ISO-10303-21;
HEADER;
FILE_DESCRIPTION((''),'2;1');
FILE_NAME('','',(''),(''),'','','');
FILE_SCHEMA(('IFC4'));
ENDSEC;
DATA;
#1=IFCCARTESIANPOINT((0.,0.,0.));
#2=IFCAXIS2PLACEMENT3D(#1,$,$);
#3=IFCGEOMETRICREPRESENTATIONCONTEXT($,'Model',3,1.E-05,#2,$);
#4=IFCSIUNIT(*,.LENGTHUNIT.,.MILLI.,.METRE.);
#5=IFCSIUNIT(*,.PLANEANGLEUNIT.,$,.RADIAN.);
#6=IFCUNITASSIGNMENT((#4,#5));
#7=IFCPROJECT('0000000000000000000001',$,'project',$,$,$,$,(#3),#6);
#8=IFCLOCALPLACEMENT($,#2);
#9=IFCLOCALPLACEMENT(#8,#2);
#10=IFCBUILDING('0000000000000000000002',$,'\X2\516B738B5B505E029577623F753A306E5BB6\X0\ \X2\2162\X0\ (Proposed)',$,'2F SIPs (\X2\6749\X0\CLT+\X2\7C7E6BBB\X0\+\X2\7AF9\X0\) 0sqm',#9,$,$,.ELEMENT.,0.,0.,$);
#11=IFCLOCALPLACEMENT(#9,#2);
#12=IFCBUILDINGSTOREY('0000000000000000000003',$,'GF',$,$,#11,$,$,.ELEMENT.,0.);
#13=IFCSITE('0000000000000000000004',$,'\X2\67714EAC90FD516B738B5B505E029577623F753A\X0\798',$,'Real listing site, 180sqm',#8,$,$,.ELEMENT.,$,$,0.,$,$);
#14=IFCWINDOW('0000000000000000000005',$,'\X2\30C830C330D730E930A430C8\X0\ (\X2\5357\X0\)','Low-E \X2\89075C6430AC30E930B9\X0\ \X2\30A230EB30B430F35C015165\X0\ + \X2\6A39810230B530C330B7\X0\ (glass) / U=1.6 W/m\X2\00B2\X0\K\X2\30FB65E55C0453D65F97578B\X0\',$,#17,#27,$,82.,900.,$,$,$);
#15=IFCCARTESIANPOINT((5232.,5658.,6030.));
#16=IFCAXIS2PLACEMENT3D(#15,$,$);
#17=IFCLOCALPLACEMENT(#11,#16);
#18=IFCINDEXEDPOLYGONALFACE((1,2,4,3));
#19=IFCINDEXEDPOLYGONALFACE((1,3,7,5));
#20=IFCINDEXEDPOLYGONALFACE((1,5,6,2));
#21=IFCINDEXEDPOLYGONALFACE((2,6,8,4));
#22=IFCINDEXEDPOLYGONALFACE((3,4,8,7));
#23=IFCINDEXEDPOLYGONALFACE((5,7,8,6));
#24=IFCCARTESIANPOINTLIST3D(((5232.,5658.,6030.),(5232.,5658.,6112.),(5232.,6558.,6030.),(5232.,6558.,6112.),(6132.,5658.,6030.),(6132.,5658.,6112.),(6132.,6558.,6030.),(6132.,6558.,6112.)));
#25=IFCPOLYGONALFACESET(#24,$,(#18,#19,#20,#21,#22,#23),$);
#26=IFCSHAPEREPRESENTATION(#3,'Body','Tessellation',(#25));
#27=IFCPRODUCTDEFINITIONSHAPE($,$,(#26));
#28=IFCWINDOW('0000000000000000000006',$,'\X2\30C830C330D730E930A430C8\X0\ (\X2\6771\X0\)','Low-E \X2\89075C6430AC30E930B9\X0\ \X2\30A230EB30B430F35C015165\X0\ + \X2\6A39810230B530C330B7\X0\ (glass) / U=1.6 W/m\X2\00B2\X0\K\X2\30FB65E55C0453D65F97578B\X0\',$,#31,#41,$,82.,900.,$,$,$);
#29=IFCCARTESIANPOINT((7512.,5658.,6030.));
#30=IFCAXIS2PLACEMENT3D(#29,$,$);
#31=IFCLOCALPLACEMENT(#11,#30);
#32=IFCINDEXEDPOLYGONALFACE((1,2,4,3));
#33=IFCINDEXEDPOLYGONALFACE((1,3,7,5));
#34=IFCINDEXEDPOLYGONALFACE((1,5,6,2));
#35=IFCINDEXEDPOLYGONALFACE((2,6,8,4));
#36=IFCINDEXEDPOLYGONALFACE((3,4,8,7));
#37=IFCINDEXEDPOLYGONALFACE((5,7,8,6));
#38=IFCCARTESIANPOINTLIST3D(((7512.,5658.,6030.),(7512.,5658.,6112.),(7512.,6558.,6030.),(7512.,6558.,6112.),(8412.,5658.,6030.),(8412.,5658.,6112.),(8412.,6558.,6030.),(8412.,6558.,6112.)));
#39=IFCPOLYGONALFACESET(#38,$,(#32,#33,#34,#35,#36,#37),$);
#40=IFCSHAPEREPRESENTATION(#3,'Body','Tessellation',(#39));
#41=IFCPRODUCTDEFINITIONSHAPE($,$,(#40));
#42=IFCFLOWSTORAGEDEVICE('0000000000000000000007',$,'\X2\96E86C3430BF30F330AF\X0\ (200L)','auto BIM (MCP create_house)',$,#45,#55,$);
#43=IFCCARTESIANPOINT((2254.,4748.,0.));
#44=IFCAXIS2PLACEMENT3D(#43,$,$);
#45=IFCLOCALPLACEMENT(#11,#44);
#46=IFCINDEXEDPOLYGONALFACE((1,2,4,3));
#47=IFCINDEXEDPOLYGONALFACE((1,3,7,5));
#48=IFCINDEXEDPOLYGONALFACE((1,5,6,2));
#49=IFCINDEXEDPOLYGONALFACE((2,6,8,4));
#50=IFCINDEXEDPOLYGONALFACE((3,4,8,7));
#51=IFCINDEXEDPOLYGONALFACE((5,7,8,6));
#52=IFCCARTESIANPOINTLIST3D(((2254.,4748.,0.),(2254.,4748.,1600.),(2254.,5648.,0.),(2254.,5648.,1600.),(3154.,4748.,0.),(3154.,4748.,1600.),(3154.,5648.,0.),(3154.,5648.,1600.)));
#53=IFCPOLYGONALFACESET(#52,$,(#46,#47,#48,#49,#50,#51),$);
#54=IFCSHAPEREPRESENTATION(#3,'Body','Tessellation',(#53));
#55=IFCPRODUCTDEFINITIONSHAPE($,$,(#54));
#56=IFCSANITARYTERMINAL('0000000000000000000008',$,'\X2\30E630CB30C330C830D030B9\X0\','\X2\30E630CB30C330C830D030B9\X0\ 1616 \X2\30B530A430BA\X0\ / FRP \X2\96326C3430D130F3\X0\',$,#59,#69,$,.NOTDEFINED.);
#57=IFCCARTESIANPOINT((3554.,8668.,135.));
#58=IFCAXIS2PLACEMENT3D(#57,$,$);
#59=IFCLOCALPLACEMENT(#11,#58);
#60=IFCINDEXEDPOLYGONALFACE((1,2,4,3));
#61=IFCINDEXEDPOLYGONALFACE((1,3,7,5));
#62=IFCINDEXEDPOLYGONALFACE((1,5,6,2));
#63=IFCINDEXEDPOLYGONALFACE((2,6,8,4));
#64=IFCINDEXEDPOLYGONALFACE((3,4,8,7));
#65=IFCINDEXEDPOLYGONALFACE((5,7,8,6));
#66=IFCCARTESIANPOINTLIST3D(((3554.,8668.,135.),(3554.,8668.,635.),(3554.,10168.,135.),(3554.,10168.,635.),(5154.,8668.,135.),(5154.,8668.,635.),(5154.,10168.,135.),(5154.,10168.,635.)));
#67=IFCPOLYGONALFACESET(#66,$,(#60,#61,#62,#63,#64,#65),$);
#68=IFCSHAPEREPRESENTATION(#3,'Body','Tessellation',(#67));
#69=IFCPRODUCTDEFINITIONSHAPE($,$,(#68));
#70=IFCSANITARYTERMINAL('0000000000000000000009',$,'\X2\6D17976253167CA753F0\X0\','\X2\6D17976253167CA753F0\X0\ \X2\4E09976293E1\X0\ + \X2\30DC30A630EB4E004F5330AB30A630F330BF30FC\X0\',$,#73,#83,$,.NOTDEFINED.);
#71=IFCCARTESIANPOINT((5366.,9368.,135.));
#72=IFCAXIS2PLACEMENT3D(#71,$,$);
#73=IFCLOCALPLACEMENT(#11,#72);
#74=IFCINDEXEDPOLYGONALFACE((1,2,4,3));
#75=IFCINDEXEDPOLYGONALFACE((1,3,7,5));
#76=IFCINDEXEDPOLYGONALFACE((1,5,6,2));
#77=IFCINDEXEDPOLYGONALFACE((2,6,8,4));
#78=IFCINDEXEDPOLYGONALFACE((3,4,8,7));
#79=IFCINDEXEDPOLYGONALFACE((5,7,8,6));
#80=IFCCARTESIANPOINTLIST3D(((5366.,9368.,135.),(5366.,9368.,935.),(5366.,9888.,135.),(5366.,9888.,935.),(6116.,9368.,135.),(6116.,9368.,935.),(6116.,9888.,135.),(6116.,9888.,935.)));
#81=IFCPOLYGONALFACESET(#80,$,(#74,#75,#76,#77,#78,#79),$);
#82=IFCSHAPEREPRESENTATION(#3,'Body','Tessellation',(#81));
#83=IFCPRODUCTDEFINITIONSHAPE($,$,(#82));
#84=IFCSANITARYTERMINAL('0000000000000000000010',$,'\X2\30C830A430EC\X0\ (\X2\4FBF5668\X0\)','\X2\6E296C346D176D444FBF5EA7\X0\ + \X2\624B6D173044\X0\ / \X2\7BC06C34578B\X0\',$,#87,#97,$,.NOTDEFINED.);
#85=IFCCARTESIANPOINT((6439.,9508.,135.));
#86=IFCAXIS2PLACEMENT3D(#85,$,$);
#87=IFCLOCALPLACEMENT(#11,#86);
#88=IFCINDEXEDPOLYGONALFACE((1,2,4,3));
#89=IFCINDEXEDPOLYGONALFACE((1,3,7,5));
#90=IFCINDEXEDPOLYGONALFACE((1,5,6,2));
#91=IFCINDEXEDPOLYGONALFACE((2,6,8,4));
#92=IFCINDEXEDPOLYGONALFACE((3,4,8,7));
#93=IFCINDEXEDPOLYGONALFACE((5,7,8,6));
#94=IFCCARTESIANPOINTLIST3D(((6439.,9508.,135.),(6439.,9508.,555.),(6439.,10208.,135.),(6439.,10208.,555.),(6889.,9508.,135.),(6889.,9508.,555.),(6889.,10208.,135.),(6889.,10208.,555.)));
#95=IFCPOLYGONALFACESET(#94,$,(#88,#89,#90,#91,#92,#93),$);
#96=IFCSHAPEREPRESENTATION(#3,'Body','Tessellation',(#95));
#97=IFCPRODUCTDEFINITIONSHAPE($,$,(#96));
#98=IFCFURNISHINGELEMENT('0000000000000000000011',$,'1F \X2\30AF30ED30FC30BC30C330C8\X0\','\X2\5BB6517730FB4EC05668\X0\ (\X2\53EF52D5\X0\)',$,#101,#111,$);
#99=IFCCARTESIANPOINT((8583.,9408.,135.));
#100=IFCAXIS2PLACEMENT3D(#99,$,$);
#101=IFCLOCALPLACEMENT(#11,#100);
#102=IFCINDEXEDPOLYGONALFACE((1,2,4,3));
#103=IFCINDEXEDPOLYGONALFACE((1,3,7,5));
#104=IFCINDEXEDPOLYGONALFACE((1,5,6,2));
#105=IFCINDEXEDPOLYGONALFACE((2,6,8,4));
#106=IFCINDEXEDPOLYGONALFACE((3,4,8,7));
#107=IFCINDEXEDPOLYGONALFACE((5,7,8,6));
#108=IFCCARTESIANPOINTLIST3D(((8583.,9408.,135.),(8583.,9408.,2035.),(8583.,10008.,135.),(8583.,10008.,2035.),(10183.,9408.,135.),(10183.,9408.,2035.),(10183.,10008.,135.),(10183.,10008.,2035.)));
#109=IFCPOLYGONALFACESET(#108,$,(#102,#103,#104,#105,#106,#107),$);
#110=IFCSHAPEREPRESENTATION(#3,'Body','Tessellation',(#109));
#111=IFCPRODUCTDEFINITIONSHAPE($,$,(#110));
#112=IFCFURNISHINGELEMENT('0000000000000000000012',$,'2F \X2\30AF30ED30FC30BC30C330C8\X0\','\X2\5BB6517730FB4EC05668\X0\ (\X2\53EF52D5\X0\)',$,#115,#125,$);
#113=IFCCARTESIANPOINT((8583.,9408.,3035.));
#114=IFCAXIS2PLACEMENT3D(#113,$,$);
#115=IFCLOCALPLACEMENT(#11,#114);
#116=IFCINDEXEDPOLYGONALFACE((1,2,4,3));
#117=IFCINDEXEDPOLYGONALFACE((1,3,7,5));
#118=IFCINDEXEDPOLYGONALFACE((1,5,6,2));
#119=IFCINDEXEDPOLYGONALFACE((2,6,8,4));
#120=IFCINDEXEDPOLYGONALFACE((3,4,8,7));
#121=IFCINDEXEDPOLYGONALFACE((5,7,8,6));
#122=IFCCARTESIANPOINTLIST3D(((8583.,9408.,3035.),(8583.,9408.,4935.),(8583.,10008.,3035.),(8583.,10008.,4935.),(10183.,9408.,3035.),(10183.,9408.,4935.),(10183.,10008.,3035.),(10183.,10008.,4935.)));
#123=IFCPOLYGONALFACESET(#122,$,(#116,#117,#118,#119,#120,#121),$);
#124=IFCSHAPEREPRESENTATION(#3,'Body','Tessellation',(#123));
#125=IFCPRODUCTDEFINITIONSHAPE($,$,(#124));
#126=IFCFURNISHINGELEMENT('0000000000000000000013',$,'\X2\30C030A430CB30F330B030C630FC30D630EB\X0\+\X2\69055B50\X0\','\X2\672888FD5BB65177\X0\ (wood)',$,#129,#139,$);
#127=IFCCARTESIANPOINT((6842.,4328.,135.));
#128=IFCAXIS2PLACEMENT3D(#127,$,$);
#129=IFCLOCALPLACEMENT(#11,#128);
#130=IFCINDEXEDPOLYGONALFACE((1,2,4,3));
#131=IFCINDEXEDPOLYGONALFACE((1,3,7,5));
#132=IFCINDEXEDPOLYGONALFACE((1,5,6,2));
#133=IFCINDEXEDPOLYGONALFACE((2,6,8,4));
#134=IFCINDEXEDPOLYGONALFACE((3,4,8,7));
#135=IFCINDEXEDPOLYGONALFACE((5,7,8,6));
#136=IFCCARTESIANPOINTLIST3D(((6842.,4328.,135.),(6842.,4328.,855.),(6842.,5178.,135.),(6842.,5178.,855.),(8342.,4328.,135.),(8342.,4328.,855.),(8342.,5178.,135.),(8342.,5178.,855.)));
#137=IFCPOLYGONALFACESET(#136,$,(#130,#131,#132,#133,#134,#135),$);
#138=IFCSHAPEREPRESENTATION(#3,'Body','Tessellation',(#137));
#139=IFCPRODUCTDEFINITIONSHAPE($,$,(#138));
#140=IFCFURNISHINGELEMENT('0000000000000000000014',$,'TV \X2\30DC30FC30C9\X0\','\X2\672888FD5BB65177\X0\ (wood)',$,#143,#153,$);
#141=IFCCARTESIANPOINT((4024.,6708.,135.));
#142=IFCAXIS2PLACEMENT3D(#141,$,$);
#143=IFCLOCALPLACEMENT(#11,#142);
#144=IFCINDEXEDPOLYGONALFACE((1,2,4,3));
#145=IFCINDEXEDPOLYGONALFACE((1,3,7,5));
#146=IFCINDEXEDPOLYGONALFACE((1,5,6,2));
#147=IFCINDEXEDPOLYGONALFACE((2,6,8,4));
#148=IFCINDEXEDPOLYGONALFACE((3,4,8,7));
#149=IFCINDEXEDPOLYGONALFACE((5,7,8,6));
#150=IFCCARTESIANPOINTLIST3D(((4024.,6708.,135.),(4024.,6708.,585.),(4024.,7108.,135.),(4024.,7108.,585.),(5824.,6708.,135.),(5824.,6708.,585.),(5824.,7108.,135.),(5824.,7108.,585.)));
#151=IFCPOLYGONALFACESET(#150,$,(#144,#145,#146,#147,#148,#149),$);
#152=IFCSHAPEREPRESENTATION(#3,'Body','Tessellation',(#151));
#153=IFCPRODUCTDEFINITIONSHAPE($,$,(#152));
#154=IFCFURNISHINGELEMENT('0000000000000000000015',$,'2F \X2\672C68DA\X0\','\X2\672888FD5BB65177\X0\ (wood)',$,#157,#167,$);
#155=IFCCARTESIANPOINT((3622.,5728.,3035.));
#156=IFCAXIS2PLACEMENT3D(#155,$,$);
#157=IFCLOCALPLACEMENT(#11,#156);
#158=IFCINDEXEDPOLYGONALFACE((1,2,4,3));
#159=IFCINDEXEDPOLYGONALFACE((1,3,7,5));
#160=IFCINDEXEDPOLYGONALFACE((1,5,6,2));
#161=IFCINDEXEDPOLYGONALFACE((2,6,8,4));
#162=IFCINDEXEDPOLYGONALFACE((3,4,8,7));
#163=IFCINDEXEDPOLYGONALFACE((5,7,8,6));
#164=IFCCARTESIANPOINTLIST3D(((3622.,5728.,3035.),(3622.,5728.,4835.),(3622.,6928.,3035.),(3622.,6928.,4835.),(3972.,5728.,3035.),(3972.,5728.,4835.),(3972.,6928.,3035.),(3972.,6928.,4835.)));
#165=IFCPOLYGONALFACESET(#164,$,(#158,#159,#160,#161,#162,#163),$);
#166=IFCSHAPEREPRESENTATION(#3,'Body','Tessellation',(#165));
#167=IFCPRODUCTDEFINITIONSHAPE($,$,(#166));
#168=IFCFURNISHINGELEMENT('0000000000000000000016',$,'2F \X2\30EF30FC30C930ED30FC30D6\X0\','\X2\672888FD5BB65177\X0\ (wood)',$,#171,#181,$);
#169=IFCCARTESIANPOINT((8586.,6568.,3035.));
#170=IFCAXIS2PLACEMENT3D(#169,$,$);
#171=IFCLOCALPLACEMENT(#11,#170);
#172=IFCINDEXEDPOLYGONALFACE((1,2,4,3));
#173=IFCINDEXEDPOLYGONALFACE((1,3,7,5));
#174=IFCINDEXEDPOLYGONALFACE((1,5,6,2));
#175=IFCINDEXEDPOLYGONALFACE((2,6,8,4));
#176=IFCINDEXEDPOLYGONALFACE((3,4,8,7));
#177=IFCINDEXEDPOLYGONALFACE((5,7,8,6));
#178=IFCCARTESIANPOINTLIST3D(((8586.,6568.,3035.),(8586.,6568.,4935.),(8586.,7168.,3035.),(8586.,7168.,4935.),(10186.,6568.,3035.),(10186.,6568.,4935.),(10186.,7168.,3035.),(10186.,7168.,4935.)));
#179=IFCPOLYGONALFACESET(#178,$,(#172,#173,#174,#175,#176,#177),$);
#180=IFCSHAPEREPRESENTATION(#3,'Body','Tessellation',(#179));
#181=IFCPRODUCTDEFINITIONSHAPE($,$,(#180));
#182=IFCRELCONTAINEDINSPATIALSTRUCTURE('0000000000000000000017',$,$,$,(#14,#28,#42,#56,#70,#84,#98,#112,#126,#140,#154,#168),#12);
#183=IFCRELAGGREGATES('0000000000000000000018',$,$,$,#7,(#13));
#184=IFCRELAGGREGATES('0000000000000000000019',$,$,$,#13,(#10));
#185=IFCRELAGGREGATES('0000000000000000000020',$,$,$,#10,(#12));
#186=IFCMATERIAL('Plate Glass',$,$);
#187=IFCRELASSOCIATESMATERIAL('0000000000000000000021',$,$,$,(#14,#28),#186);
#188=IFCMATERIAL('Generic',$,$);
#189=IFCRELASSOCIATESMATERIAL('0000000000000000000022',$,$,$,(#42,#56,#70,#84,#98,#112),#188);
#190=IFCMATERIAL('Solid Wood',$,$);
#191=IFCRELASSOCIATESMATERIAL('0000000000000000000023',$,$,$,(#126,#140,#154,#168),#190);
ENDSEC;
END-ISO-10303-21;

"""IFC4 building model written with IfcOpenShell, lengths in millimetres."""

from ifc_helpers import new_model, si_unit, frame, frame_2d, origin, place, context, project, spatial, rectangle, extrude, material, element, save


model = new_model("IFC4")

# Units and contexts
model_context = context("Model", 3, precision=1e-05, world=origin())
ifc_project = project(units=[si_unit("LENGTHUNIT", "METRE", prefix="MILLI"), si_unit("PLANEANGLEUNIT", "RADIAN")], contexts=[model_context])

# Site, building, storey
site_placement = place(None, origin())
site = spatial("IfcSite", under=ifc_project, at=site_placement, Name="東京都八王子市長房町798", ObjectType="Real listing site, 180sqm", CompositionType="ELEMENT", RefElevation=0.0)
building_placement = place(site_placement, origin())
building = spatial("IfcBuilding", under=site, at=building_placement, Name="八王子市長房町の家 Ⅲ (Proposed)", ObjectType="2F SIPs (杉CLT+籾殻+竹) 0sqm", CompositionType="ELEMENT", ElevationOfRefHeight=0.0, ElevationOfTerrain=0.0)
storey_placement = place(building_placement, origin())
storey = spatial("IfcBuildingStorey", under=building, at=storey_placement, Name="GF", CompositionType="ELEMENT", Elevation=0.0)

# Shared definitions
ifc_material_1 = material(Name="Solid Wood")
ifc_material_2 = material(Name="Plate Glass")

# Windows
window_1_placement = place(storey_placement, frame((5232.0, 5658.0, 6030.0)))
element("IfcWindow", 1, at=window_1_placement, inside=storey, material=ifc_material_2, Name="トップライト (南)", Description="Low-E 複層ガラス アルゴン封入 + 樹脂サッシ (glass) / U=1.6 W/m²K・日射取得型", OverallHeight=82.0, OverallWidth=900.0, context=model_context, shape_type="SweptSolid", body=[
    extrude(rectangle(XDim=900.0, YDim=900.0, at=frame_2d((450.0, 450.0))), frame((5232.0, 5658.0, 6030.0)), (0.0, 0.0, 1.0), 82.0),
])
window_2_placement = place(storey_placement, frame((7512.0, 5658.0, 6030.0)))
element("IfcWindow", 2, at=window_2_placement, inside=storey, material=ifc_material_2, Name="トップライト (東)", Description="Low-E 複層ガラス アルゴン封入 + 樹脂サッシ (glass) / U=1.6 W/m²K・日射取得型", OverallHeight=82.0, OverallWidth=900.0, context=model_context, shape_type="SweptSolid", body=[
    extrude(rectangle(XDim=900.0, YDim=900.0, at=frame_2d((450.0, 450.0))), frame((7512.0, 5658.0, 6030.0)), (0.0, 0.0, 1.0), 82.0),
])

# Flow storage device
ifc_material_3 = material(Name="Generic")
flow_storage_device_placement = place(storey_placement, frame((2254.0, 4748.0, 0.0)))
element("IfcFlowStorageDevice", 3, at=flow_storage_device_placement, inside=storey, material=ifc_material_3, Name="雨水タンク (200L)", Description="auto BIM (MCP create_house)", context=model_context, shape_type="SweptSolid", body=[
    extrude(rectangle(XDim=900.0, YDim=900.0, at=frame_2d((450.0, 450.0))), frame((2254.0, 4748.0, 0.0)), (0.0, 0.0, 1.0), 1600.0),
])

# Sanitary terminals
sanitary_terminal_1_placement = place(storey_placement, frame((3554.0, 8668.0, 135.0)))
element("IfcSanitaryTerminal", 4, at=sanitary_terminal_1_placement, inside=storey, material=ifc_material_3, Name="ユニットバス", Description="ユニットバス 1616 サイズ / FRP 防水パン", PredefinedType="NOTDEFINED", context=model_context, shape_type="SweptSolid", body=[
    extrude(rectangle(XDim=1600.0, YDim=1500.0, at=frame_2d((800.0, 750.0))), frame((3554.0, 8668.0, 135.0)), (0.0, 0.0, 1.0), 500.0),
])
sanitary_terminal_2_placement = place(storey_placement, frame((5366.0, 9368.0, 135.0)))
element("IfcSanitaryTerminal", 5, at=sanitary_terminal_2_placement, inside=storey, material=ifc_material_3, Name="洗面化粧台", Description="洗面化粧台 三面鏡 + ボウル一体カウンター", PredefinedType="NOTDEFINED", context=model_context, shape_type="SweptSolid", body=[
    extrude(rectangle(XDim=750.0, YDim=520.0, at=frame_2d((375.0, 260.0))), frame((5366.0, 9368.0, 135.0)), (0.0, 0.0, 1.0), 800.0),
])
sanitary_terminal_3_placement = place(storey_placement, frame((6439.0, 9508.0, 135.0)))
element("IfcSanitaryTerminal", 6, at=sanitary_terminal_3_placement, inside=storey, material=ifc_material_3, Name="トイレ (便器)", Description="温水洗浄便座 + 手洗い / 節水型", PredefinedType="NOTDEFINED", context=model_context, shape_type="SweptSolid", body=[
    extrude(rectangle(XDim=450.0, YDim=700.0, at=frame_2d((225.0, 350.0))), frame((6439.0, 9508.0, 135.0)), (0.0, 0.0, 1.0), 420.0),
])

# Furnishing elements
furnishing_1_placement = place(storey_placement, frame((8583.0, 9408.0, 135.0)))
element("IfcFurnishingElement", 7, at=furnishing_1_placement, inside=storey, material=ifc_material_3, Name="1F クローゼット", Description="家具・什器 (可動)", context=model_context, shape_type="SweptSolid", body=[
    extrude(rectangle(XDim=1600.0, YDim=600.0, at=frame_2d((800.0, 300.0))), frame((8583.0, 9408.0, 135.0)), (0.0, 0.0, 1.0), 1900.0),
])
furnishing_2_placement = place(storey_placement, frame((8583.0, 9408.0, 3035.0)))
element("IfcFurnishingElement", 8, at=furnishing_2_placement, inside=storey, material=ifc_material_3, Name="2F クローゼット", Description="家具・什器 (可動)", context=model_context, shape_type="SweptSolid", body=[
    extrude(rectangle(XDim=1600.0, YDim=600.0, at=frame_2d((800.0, 300.0))), frame((8583.0, 9408.0, 3035.0)), (0.0, 0.0, 1.0), 1900.0),
])
furnishing_3_placement = place(storey_placement, frame((6842.0, 4328.0, 135.0)))
element("IfcFurnishingElement", 9, at=furnishing_3_placement, inside=storey, material=ifc_material_1, Name="ダイニングテーブル+椅子", Description="木製家具 (wood)", context=model_context, shape_type="SweptSolid", body=[
    extrude(rectangle(XDim=1500.0, YDim=850.0, at=frame_2d((750.0, 425.0))), frame((6842.0, 4328.0, 135.0)), (0.0, 0.0, 1.0), 720.0),
])
furnishing_4_placement = place(storey_placement, frame((4024.0, 6708.0, 135.0)))
element("IfcFurnishingElement", 10, at=furnishing_4_placement, inside=storey, material=ifc_material_1, Name="TV ボード", Description="木製家具 (wood)", context=model_context, shape_type="SweptSolid", body=[
    extrude(rectangle(XDim=1800.0, YDim=400.0, at=frame_2d((900.0, 200.0))), frame((4024.0, 6708.0, 135.0)), (0.0, 0.0, 1.0), 450.0),
])
furnishing_5_placement = place(storey_placement, frame((3622.0, 5728.0, 3035.0)))
element("IfcFurnishingElement", 11, at=furnishing_5_placement, inside=storey, material=ifc_material_1, Name="2F 本棚", Description="木製家具 (wood)", context=model_context, shape_type="SweptSolid", body=[
    extrude(rectangle(XDim=350.0, YDim=1200.0, at=frame_2d((175.0, 600.0))), frame((3622.0, 5728.0, 3035.0)), (0.0, 0.0, 1.0), 1800.0),
])
furnishing_6_placement = place(storey_placement, frame((8586.0, 6568.0, 3035.0)))
element("IfcFurnishingElement", 12, at=furnishing_6_placement, inside=storey, material=ifc_material_1, Name="2F ワードローブ", Description="木製家具 (wood)", context=model_context, shape_type="SweptSolid", body=[
    extrude(rectangle(XDim=1600.0, YDim=600.0, at=frame_2d((800.0, 300.0))), frame((8586.0, 6568.0, 3035.0)), (0.0, 0.0, 1.0), 1900.0),
])

save(model, "model.ifc")
